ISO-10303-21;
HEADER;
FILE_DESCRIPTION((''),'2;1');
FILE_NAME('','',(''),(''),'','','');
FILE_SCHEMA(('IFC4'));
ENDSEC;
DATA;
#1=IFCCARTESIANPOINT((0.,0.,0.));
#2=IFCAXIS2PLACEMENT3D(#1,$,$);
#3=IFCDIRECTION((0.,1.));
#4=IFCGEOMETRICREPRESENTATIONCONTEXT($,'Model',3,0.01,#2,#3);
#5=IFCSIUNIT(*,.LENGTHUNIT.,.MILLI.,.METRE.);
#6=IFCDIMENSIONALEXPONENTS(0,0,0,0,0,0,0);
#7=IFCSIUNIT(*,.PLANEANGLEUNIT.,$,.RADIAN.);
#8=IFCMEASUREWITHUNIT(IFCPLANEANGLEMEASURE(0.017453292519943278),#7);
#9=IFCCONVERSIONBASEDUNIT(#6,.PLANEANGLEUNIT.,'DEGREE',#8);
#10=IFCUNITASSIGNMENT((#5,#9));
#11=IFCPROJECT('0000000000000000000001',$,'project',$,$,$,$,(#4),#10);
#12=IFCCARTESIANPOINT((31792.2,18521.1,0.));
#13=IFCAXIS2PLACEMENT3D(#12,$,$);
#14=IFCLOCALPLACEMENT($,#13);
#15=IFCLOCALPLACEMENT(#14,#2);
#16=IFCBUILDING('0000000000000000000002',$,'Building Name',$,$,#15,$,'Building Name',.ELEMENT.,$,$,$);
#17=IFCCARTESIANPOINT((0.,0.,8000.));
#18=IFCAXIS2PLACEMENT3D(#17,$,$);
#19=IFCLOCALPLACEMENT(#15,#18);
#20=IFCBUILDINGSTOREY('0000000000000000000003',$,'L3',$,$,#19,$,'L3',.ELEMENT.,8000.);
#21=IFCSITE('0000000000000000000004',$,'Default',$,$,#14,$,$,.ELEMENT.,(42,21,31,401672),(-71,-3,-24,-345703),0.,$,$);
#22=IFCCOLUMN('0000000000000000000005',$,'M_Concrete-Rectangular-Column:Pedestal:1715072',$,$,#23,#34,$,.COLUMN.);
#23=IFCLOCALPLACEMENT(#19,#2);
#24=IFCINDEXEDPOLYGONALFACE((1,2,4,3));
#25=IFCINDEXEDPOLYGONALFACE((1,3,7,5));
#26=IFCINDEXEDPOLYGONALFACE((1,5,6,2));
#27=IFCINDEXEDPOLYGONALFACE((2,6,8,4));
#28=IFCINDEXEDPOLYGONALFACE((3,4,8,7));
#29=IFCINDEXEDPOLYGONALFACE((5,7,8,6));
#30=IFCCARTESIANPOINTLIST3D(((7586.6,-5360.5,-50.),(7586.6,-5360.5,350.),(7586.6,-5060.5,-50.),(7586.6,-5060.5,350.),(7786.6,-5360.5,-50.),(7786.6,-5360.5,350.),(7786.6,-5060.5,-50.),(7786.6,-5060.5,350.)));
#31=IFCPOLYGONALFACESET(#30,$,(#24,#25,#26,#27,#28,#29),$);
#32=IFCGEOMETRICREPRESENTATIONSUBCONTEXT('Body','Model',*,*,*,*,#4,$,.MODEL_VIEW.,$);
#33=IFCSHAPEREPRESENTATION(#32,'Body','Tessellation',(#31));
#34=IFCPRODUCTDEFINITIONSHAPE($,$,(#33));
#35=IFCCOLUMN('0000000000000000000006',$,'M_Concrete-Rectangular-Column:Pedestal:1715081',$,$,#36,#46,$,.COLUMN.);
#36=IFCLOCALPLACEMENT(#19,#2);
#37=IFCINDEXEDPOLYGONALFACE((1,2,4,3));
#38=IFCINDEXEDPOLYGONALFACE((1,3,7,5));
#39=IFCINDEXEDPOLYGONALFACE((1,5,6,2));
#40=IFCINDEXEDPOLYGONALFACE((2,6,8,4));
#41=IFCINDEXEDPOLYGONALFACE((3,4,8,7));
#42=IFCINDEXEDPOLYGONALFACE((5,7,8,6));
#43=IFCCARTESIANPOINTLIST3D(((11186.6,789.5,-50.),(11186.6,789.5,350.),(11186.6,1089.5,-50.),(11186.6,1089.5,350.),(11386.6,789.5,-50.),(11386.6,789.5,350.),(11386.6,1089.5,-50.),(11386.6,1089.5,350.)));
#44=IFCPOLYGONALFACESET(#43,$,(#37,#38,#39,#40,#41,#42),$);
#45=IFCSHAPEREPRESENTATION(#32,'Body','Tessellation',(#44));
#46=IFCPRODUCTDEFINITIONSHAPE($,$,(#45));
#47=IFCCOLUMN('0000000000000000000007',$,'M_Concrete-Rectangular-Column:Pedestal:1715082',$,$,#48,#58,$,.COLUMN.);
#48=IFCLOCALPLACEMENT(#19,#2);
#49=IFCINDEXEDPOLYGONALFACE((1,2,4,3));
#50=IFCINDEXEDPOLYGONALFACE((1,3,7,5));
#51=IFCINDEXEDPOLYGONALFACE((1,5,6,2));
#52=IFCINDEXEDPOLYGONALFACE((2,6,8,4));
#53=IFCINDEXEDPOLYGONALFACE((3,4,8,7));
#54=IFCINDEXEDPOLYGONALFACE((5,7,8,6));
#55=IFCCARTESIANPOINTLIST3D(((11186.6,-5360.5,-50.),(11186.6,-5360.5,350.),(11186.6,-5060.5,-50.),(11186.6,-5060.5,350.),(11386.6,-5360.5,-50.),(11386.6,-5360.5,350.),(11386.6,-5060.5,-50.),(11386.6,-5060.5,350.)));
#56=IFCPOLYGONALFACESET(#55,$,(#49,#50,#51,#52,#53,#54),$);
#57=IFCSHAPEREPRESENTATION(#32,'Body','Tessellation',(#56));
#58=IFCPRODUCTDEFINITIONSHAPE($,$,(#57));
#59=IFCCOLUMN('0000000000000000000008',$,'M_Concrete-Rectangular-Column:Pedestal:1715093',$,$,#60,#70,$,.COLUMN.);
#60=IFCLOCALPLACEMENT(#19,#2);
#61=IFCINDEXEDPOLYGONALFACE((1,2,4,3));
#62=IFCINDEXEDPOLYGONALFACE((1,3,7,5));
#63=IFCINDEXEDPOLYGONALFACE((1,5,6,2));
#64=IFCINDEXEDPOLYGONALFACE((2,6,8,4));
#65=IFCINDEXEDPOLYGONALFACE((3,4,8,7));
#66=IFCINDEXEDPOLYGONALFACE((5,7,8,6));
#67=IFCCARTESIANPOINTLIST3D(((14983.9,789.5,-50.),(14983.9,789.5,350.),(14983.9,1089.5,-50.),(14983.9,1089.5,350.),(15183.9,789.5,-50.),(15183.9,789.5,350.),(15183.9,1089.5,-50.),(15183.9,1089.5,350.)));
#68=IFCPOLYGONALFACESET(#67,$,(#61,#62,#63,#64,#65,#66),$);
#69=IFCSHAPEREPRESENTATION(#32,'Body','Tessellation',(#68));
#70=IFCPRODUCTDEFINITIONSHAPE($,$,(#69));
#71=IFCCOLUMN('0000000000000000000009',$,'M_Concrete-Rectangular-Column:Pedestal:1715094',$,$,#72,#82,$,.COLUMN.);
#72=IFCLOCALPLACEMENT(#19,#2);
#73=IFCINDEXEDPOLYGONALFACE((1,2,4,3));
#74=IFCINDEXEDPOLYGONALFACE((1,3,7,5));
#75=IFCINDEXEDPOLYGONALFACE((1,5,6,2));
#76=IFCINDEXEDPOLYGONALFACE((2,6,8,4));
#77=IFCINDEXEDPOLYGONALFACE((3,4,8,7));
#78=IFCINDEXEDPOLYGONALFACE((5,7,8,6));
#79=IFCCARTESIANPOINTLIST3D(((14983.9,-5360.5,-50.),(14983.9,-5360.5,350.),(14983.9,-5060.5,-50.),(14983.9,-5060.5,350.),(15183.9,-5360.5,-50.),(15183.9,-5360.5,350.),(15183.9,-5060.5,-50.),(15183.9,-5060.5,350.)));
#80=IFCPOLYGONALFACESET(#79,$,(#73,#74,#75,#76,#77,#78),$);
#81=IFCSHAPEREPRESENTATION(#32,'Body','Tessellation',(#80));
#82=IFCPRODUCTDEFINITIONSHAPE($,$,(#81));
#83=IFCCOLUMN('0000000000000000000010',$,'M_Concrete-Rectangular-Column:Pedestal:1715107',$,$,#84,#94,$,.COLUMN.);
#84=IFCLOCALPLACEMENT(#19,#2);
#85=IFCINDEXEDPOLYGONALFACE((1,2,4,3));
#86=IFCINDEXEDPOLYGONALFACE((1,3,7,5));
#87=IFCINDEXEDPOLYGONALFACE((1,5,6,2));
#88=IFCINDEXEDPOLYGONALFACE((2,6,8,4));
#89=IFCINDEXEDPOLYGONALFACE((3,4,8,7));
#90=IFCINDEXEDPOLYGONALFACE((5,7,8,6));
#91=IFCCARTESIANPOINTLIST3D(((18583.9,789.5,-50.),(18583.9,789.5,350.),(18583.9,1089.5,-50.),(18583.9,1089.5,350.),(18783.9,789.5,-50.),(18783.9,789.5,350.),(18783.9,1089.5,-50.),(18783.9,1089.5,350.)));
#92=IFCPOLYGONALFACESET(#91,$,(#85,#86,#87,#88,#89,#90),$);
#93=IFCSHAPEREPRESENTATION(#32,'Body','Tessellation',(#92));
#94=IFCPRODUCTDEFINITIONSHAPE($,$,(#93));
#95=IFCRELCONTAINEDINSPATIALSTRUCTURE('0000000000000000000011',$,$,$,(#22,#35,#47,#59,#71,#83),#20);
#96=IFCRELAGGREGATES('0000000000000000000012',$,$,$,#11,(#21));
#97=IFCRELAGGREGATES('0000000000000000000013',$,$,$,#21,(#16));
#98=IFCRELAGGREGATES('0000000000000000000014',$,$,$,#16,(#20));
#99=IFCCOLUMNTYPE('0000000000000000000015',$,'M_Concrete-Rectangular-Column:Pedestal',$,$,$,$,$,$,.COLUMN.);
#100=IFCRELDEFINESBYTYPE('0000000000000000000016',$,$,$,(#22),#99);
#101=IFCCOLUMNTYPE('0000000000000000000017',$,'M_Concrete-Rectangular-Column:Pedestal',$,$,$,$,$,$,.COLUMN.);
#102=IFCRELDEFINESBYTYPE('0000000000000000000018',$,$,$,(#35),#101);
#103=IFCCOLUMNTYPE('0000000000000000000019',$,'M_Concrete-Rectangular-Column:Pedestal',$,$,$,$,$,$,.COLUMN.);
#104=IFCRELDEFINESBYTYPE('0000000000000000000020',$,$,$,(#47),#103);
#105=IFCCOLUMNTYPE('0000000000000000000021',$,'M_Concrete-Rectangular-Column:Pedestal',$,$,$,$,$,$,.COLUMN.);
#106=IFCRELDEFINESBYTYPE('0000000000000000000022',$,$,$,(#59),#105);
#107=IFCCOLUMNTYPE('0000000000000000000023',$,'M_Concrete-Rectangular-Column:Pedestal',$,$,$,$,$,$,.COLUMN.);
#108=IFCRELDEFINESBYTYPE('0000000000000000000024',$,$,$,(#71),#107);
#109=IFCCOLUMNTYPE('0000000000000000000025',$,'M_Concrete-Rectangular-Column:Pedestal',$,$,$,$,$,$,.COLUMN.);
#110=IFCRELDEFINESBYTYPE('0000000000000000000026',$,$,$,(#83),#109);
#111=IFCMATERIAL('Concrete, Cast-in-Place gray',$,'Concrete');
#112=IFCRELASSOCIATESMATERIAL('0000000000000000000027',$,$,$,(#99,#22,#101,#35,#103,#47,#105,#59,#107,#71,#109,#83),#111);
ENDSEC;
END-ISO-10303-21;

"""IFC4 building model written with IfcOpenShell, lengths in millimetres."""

from ifc_helpers import new_model, entity, si_unit, converted_unit, direction, frame, origin, place, context, subcontext, project, spatial, indexed_curve, outline, extrude, source, transform, mapped, material, type_object, type_shapes, element, save


model = new_model("IFC4")

# Units and contexts
model_context = context("Model", 3, precision=0.01, world=origin(), true_north=direction((0.0, 1.0)))
body_context = subcontext(model_context, "Body", "Model", "MODEL_VIEW")
ifc_project = project(units=[si_unit("LENGTHUNIT", "METRE", prefix="MILLI"), converted_unit("PLANEANGLEUNIT", "DEGREE", entity("IfcPlaneAngleMeasure", 0.017453292519943278), si_unit("PLANEANGLEUNIT", "RADIAN"), dimensions=[0, 0, 0, 0, 0, 0, 0])], contexts=[model_context])

# Site, building, storey
site_placement = place(None, frame((31792.2, 18521.1, 0.0)))
site = spatial("IfcSite", under=ifc_project, at=site_placement, Name="Default", CompositionType="ELEMENT", RefLatitude=(42, 21, 31, 401672), RefLongitude=(-71, -3, -24, -345703), RefElevation=0.0)
building_placement = place(site_placement, origin())
building = spatial("IfcBuilding", under=site, at=building_placement, Name="Building Name", LongName="Building Name", CompositionType="ELEMENT")
storey_placement = place(building_placement, frame((0.0, 0.0, 8000.0)))
storey = spatial("IfcBuildingStorey", under=building, at=storey_placement, Name="L3", LongName="L3", CompositionType="ELEMENT", Elevation=8000.0)

# Columns
ifc_material_1 = material(Name="Concrete, Cast-in-Place gray", Category="Concrete")
column_type_1 = type_object("IfcColumnType", Name="M_Concrete-Rectangular-Column:Pedestal", PredefinedType="COLUMN", material=ifc_material_1)
shared_shape_1 = source(origin(), body_context, "Body", "SweptSolid", [
    extrude(outline(indexed_curve([(-150.0, -100.0), (150.0, -100.0), (150.0, 100.0), (-150.0, 100.0), (-150.0, -100.0)], self_intersect=False)), frame((7686.6, -5210.5, 7950.0), z_axis=(0.0, 0.0, 1.0), x_axis=(0.0, -1.0, 0.0)), (0.0, 0.0, 1.0), 400.0),
])
type_shapes(column_type_1, [shared_shape_1])
column_1_placement = place(storey_placement, frame((0.0, 0.0, -8000.0)))
element("IfcColumn", 1, at=column_1_placement, inside=storey, type_object=column_type_1, material=ifc_material_1, Name="M_Concrete-Rectangular-Column:Pedestal:1715072", PredefinedType="COLUMN", context=body_context, shape_type="MappedRepresentation", body=[
    mapped(shared_shape_1, transform((0.0, 0.0, 0.0), scale=1.0)),
])
column_type_2 = type_object("IfcColumnType", Name="M_Concrete-Rectangular-Column:Pedestal", PredefinedType="COLUMN", material=ifc_material_1)
shared_shape_2 = source(origin(), body_context, "Body", "SweptSolid", [
    extrude(outline(indexed_curve([(-150.0, -100.0), (150.0, -100.0), (150.0, 100.0), (-150.0, 100.0), (-150.0, -100.0)], self_intersect=False)), frame((11286.6, 939.5, 7950.0), z_axis=(0.0, 0.0, 1.0), x_axis=(0.0, -1.0, 0.0)), (0.0, 0.0, 1.0), 400.0),
])
type_shapes(column_type_2, [shared_shape_2])
column_2_placement = place(storey_placement, frame((0.0, 0.0, -8000.0)))
element("IfcColumn", 2, at=column_2_placement, inside=storey, type_object=column_type_2, material=ifc_material_1, Name="M_Concrete-Rectangular-Column:Pedestal:1715081", PredefinedType="COLUMN", context=body_context, shape_type="MappedRepresentation", body=[
    mapped(shared_shape_2, transform((0.0, 0.0, 0.0), scale=1.0)),
])
column_type_3 = type_object("IfcColumnType", Name="M_Concrete-Rectangular-Column:Pedestal", PredefinedType="COLUMN", material=ifc_material_1)
shared_shape_3 = source(origin(), body_context, "Body", "SweptSolid", [
    extrude(outline(indexed_curve([(-150.0, -100.0), (150.0, -100.0), (150.0, 100.0), (-150.0, 100.0), (-150.0, -100.0)], self_intersect=False)), frame((11286.6, -5210.5, 7950.0), z_axis=(0.0, 0.0, 1.0), x_axis=(0.0, -1.0, 0.0)), (0.0, 0.0, 1.0), 400.0),
])
type_shapes(column_type_3, [shared_shape_3])
column_3_placement = place(storey_placement, frame((0.0, 0.0, -8000.0)))
element("IfcColumn", 3, at=column_3_placement, inside=storey, type_object=column_type_3, material=ifc_material_1, Name="M_Concrete-Rectangular-Column:Pedestal:1715082", PredefinedType="COLUMN", context=body_context, shape_type="MappedRepresentation", body=[
    mapped(shared_shape_3, transform((0.0, 0.0, 0.0), scale=1.0)),
])
column_type_4 = type_object("IfcColumnType", Name="M_Concrete-Rectangular-Column:Pedestal", PredefinedType="COLUMN", material=ifc_material_1)
shared_shape_4 = source(origin(), body_context, "Body", "SweptSolid", [
    extrude(outline(indexed_curve([(-150.0, -100.0), (150.0, -100.0), (150.0, 100.0), (-150.0, 100.0), (-150.0, -100.0)], self_intersect=False)), frame((15083.9, 939.5, 7950.0), z_axis=(0.0, 0.0, 1.0), x_axis=(0.0, -1.0, 0.0)), (0.0, 0.0, 1.0), 400.0),
])
type_shapes(column_type_4, [shared_shape_4])
column_4_placement = place(storey_placement, frame((0.0, 0.0, -8000.0)))
element("IfcColumn", 4, at=column_4_placement, inside=storey, type_object=column_type_4, material=ifc_material_1, Name="M_Concrete-Rectangular-Column:Pedestal:1715093", PredefinedType="COLUMN", context=body_context, shape_type="MappedRepresentation", body=[
    mapped(shared_shape_4, transform((0.0, 0.0, 0.0), scale=1.0)),
])
column_type_5 = type_object("IfcColumnType", Name="M_Concrete-Rectangular-Column:Pedestal", PredefinedType="COLUMN", material=ifc_material_1)
shared_shape_5 = source(origin(), body_context, "Body", "SweptSolid", [
    extrude(outline(indexed_curve([(-150.0, -100.0), (150.0, -100.0), (150.0, 100.0), (-150.0, 100.0), (-150.0, -100.0)], self_intersect=False)), frame((15083.9, -5210.5, 7950.0), z_axis=(0.0, 0.0, 1.0), x_axis=(0.0, -1.0, 0.0)), (0.0, 0.0, 1.0), 400.0),
])
type_shapes(column_type_5, [shared_shape_5])
column_5_placement = place(storey_placement, frame((0.0, 0.0, -8000.0)))
element("IfcColumn", 5, at=column_5_placement, inside=storey, type_object=column_type_5, material=ifc_material_1, Name="M_Concrete-Rectangular-Column:Pedestal:1715094", PredefinedType="COLUMN", context=body_context, shape_type="MappedRepresentation", body=[
    mapped(shared_shape_5, transform((0.0, 0.0, 0.0), scale=1.0)),
])
column_type_6 = type_object("IfcColumnType", Name="M_Concrete-Rectangular-Column:Pedestal", PredefinedType="COLUMN", material=ifc_material_1)
shared_shape_6 = source(origin(), body_context, "Body", "SweptSolid", [
    extrude(outline(indexed_curve([(-150.0, -100.0), (150.0, -100.0), (150.0, 100.0), (-150.0, 100.0), (-150.0, -100.0)], self_intersect=False)), frame((18683.9, 939.5, 7950.0), z_axis=(0.0, 0.0, 1.0), x_axis=(0.0, -1.0, 0.0)), (0.0, 0.0, 1.0), 400.0),
])
type_shapes(column_type_6, [shared_shape_6])
column_6_placement = place(storey_placement, frame((0.0, 0.0, -8000.0)))
element("IfcColumn", 6, at=column_6_placement, inside=storey, type_object=column_type_6, material=ifc_material_1, Name="M_Concrete-Rectangular-Column:Pedestal:1715107", PredefinedType="COLUMN", context=body_context, shape_type="MappedRepresentation", body=[
    mapped(shared_shape_6, transform((0.0, 0.0, 0.0), scale=1.0)),
])

save(model, "model.ifc")
